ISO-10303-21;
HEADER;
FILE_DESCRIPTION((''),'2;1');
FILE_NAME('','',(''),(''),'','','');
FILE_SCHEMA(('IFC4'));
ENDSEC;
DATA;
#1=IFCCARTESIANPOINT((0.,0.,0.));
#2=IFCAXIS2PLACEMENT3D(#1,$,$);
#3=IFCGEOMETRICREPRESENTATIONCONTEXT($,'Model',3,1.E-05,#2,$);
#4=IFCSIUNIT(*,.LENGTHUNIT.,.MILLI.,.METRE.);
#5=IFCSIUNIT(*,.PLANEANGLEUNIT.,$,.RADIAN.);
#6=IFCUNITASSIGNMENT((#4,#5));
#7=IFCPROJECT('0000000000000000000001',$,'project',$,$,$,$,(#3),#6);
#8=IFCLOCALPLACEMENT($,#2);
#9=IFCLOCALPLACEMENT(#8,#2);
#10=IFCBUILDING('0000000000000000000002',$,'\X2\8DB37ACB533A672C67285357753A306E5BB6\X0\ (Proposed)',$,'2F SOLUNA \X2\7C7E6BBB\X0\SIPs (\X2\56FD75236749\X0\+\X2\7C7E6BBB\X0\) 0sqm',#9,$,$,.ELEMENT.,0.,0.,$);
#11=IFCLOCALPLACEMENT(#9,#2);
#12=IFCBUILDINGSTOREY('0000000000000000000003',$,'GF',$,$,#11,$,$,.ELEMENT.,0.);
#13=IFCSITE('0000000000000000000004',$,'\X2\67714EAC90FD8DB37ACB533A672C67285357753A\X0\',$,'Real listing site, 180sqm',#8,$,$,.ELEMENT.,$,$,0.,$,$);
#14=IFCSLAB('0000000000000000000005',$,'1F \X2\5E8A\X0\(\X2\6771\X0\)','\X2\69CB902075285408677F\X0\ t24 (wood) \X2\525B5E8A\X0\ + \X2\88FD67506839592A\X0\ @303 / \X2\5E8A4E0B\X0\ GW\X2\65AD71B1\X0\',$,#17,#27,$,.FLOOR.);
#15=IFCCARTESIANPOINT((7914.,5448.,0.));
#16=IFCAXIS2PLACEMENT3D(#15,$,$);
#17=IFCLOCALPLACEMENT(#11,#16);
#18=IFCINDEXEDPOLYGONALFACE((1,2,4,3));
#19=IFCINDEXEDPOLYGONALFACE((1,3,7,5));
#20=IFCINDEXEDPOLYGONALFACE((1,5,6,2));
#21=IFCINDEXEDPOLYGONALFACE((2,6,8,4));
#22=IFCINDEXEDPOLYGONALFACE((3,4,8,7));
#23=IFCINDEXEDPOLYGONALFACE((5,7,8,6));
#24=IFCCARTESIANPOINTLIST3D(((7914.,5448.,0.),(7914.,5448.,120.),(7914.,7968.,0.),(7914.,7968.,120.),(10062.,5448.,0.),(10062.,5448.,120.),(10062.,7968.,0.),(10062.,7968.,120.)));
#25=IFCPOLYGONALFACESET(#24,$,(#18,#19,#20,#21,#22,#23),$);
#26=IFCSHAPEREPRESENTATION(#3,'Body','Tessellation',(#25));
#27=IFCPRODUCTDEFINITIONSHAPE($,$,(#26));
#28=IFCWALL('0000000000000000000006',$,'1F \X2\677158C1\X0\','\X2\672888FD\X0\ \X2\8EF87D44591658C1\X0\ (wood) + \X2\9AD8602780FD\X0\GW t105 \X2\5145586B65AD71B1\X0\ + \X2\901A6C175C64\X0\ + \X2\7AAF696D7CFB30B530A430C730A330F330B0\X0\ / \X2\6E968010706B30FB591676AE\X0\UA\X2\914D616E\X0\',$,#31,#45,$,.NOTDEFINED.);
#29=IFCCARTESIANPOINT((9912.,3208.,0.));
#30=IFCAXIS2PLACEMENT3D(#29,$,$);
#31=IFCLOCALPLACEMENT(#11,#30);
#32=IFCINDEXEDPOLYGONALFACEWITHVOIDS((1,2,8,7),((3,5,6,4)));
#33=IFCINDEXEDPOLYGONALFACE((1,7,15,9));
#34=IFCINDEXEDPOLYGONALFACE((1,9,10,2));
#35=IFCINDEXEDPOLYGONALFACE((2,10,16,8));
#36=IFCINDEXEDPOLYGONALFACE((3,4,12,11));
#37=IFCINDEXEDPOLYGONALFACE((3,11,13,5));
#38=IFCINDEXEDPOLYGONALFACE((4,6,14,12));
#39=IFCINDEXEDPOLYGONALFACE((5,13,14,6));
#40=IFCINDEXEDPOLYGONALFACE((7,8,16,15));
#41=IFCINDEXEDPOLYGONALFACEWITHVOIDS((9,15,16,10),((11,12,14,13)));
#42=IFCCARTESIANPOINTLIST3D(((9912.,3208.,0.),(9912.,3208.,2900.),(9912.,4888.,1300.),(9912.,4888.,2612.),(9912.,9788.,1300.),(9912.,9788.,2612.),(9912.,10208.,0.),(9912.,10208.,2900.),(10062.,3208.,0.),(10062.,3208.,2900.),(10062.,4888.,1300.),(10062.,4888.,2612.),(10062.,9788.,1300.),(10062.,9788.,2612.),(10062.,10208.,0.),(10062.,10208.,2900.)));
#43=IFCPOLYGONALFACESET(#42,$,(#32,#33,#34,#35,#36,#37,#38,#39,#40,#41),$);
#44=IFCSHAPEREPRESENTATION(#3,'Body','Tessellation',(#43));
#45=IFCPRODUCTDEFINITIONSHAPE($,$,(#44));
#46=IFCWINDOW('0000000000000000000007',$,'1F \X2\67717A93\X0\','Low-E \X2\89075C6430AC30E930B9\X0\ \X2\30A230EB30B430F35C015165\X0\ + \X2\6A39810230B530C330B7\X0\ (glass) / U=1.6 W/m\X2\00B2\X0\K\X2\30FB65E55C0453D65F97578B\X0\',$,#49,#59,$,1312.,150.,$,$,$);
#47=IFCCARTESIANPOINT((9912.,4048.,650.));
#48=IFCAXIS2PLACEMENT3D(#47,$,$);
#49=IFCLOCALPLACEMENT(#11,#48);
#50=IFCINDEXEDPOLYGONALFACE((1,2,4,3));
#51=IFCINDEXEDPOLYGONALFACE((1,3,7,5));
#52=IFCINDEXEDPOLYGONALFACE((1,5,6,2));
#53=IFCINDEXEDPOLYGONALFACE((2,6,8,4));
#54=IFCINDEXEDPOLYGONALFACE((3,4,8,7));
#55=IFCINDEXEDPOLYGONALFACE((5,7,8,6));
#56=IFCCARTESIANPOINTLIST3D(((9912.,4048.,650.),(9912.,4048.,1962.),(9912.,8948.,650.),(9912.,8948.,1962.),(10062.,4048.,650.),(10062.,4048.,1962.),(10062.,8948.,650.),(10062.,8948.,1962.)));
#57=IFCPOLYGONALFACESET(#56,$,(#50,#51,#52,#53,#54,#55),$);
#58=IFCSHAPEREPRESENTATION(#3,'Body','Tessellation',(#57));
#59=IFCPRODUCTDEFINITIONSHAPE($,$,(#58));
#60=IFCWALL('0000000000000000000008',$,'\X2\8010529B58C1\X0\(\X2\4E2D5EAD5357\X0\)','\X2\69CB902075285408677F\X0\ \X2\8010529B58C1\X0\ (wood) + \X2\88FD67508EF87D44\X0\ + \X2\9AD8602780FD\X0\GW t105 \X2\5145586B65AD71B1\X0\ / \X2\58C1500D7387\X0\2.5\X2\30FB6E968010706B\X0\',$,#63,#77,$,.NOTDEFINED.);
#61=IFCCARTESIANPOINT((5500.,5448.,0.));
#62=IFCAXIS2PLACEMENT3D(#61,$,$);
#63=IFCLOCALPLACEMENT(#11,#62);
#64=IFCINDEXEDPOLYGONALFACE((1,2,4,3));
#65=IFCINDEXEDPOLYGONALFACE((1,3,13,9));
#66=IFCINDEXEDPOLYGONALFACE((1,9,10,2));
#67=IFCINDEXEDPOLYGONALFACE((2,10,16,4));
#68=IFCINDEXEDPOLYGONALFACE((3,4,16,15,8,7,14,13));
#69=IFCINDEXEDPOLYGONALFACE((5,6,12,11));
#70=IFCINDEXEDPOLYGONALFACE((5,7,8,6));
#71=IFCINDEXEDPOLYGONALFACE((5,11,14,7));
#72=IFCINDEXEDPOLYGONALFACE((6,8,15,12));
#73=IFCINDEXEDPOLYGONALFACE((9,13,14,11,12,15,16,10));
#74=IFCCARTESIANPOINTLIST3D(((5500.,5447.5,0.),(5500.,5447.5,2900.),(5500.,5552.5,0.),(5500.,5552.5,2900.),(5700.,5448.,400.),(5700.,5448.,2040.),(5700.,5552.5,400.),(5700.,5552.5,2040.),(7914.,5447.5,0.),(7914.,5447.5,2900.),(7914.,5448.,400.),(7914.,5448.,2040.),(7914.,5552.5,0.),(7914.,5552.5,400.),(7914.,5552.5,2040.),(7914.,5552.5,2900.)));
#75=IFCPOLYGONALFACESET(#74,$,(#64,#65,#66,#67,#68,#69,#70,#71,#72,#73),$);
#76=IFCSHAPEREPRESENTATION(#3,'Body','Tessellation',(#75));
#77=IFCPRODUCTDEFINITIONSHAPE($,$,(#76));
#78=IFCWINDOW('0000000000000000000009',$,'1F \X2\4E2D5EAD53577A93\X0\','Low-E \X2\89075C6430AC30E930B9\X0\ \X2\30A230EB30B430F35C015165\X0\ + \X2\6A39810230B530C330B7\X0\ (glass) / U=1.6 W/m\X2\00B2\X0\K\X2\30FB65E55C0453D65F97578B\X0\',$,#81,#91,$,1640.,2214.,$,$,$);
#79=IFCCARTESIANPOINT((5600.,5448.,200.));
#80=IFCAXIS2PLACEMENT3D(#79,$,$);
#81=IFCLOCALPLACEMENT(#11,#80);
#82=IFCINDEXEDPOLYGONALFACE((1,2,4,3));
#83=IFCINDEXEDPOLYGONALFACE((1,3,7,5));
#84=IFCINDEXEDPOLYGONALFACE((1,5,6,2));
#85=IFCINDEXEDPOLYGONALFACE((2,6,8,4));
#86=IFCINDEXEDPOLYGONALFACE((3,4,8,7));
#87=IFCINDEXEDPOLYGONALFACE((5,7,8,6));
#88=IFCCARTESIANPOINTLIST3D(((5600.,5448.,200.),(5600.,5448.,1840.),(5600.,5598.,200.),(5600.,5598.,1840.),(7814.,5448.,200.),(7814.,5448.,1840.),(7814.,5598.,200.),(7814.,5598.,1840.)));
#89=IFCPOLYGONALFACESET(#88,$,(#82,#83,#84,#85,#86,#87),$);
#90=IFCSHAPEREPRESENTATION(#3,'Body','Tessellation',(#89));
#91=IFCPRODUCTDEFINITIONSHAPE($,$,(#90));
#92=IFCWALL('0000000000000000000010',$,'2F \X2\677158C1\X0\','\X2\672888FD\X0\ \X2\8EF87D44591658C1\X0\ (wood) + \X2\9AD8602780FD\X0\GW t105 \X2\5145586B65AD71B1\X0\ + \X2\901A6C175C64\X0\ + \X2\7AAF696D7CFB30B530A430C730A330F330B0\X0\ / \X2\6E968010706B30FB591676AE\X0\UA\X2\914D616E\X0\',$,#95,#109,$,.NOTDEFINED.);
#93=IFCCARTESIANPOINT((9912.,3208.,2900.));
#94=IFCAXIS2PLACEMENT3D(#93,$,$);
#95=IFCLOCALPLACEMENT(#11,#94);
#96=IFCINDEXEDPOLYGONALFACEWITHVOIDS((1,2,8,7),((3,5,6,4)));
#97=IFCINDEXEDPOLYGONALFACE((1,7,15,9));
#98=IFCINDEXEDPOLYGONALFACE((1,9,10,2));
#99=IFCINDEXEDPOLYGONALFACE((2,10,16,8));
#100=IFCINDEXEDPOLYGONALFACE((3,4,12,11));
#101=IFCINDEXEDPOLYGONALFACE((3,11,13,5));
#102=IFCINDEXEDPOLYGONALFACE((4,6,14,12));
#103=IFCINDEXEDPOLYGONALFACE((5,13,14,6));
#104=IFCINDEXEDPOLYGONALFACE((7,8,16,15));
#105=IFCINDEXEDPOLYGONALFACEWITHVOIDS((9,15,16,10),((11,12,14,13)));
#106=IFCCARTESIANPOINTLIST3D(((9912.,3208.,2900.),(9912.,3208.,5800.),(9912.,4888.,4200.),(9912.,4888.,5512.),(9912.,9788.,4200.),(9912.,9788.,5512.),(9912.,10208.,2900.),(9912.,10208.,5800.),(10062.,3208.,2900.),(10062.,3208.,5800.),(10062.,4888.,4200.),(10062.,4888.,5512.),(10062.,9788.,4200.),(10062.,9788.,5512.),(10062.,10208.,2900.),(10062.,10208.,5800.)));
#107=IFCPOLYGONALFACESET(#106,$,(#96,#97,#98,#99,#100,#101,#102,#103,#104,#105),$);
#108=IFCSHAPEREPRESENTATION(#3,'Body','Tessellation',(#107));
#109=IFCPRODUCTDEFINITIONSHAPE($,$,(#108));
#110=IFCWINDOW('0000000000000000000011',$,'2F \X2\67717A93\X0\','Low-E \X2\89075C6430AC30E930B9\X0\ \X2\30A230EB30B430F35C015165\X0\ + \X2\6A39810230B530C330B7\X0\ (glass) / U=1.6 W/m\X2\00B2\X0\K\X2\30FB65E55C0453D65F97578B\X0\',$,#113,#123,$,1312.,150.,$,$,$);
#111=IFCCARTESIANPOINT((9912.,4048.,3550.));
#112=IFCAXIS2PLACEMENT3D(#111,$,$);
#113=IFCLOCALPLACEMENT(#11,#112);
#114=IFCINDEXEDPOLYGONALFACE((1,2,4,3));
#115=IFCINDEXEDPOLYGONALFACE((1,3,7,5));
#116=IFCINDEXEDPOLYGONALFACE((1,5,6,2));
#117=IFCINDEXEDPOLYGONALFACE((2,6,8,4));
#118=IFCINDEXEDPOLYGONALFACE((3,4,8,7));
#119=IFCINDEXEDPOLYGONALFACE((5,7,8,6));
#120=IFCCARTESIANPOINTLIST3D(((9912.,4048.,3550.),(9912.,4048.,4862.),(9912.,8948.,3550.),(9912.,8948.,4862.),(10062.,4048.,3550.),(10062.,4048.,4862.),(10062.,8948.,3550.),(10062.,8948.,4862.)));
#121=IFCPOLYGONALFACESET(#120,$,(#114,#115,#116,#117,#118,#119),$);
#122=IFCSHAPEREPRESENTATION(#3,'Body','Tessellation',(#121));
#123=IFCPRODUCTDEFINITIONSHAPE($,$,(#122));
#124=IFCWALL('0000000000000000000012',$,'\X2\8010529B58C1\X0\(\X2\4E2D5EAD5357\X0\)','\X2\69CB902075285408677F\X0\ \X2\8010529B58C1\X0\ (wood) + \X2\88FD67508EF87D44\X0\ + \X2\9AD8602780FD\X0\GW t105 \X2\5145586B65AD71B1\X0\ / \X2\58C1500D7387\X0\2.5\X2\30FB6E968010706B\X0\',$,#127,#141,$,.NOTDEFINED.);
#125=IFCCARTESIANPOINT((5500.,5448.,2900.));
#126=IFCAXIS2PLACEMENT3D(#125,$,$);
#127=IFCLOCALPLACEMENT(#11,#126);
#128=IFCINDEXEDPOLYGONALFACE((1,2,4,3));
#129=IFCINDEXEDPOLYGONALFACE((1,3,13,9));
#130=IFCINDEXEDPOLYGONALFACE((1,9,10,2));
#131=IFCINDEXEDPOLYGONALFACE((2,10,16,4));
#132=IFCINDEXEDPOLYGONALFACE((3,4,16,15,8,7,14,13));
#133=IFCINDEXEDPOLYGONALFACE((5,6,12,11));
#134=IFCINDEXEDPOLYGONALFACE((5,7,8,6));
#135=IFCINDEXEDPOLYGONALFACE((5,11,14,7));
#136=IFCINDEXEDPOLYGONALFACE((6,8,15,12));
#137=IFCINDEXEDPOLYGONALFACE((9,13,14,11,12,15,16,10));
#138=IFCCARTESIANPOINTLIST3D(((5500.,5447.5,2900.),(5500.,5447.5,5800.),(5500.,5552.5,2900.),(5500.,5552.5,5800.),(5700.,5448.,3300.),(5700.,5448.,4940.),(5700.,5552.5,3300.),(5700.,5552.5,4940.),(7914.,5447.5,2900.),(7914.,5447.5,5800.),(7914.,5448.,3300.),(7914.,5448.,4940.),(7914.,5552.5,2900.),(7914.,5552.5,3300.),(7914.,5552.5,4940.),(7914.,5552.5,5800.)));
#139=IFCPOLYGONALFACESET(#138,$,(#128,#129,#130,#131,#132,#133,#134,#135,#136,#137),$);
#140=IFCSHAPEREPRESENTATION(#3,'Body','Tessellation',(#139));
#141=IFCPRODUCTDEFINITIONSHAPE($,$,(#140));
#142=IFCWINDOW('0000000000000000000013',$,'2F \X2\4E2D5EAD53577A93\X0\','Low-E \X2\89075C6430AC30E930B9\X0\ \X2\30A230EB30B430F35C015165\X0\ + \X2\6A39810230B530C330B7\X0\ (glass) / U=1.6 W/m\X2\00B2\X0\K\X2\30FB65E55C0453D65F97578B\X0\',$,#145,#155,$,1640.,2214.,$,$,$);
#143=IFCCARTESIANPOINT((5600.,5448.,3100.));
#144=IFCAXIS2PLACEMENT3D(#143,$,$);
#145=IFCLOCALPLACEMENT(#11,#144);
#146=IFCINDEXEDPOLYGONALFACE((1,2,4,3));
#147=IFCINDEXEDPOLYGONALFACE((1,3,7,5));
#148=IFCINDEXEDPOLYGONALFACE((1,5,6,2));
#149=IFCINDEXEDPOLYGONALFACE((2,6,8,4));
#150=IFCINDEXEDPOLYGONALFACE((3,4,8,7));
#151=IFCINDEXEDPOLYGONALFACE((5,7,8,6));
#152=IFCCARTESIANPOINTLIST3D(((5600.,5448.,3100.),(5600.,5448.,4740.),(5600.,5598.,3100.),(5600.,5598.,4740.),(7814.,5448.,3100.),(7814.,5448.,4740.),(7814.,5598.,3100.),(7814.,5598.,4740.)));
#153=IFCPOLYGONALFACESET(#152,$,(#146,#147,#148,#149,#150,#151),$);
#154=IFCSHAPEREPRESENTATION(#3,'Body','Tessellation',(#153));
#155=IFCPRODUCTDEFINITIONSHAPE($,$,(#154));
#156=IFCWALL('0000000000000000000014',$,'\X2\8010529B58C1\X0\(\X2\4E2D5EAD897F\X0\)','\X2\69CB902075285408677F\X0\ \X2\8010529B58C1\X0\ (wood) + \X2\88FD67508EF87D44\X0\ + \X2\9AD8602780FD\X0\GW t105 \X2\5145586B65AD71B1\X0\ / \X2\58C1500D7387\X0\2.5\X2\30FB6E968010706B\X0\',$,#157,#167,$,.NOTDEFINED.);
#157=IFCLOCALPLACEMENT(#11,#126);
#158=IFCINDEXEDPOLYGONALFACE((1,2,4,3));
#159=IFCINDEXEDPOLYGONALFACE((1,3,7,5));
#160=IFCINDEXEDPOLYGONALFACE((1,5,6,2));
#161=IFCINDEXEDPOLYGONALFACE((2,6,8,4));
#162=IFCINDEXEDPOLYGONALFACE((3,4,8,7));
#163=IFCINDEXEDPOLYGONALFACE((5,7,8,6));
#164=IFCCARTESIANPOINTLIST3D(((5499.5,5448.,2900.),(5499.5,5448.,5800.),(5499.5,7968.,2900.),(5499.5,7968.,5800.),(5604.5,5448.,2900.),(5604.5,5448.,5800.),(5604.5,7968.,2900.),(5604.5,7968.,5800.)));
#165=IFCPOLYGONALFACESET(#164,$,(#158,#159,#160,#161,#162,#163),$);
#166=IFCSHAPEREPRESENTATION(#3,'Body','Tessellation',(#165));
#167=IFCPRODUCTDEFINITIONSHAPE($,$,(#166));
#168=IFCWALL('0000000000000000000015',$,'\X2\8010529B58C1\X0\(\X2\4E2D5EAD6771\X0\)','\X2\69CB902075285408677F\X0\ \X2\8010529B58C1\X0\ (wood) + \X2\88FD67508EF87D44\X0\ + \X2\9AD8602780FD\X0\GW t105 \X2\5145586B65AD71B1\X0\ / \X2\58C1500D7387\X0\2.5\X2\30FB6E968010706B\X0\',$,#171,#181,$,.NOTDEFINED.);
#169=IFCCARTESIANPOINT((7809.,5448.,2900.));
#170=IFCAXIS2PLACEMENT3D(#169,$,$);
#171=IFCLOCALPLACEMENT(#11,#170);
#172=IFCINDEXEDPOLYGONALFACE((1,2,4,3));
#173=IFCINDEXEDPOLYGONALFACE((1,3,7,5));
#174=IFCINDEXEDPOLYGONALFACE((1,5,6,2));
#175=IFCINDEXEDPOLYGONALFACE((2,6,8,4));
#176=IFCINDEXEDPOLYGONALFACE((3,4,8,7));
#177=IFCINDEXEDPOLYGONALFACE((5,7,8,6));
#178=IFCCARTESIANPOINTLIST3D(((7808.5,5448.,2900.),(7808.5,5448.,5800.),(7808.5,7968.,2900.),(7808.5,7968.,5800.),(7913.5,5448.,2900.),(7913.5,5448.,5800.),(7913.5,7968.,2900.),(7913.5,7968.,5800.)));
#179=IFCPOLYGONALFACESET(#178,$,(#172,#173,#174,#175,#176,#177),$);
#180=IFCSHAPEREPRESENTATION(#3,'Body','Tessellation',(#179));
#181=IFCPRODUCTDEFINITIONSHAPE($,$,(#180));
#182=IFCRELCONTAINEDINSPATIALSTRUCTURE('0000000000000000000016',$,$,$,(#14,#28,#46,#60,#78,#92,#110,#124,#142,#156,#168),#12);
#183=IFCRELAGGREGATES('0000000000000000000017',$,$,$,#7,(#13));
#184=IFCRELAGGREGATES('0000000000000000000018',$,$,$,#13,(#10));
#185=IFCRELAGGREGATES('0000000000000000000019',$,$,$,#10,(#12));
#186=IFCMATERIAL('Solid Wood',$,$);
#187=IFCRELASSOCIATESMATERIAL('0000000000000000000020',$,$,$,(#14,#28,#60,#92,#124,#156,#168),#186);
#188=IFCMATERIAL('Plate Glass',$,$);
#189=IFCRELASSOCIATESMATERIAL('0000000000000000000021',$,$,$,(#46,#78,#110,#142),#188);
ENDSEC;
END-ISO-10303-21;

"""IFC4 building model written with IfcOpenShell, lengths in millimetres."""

from ifc_helpers import new_model, si_unit, frame, frame_2d, origin, place, context, project, spatial, rectangle, extrude, material, element, fill, save


model = new_model("IFC4")

# Units and contexts
model_context = context("Model", 3, precision=1e-05, world=origin())
ifc_project = project(units=[si_unit("LENGTHUNIT", "METRE", prefix="MILLI"), si_unit("PLANEANGLEUNIT", "RADIAN")], contexts=[model_context])

# Site, building, storey
site_placement = place(None, origin())
site = spatial("IfcSite", under=ifc_project, at=site_placement, Name="東京都足立区本木南町", ObjectType="Real listing site, 180sqm", CompositionType="ELEMENT", RefElevation=0.0)
building_placement = place(site_placement, origin())
building = spatial("IfcBuilding", under=site, at=building_placement, Name="足立区本木南町の家 (Proposed)", ObjectType="2F SOLUNA 籾殻SIPs (国産杉+籾殻) 0sqm", CompositionType="ELEMENT", ElevationOfRefHeight=0.0, ElevationOfTerrain=0.0)
storey_placement = place(building_placement, origin())
storey = spatial("IfcBuildingStorey", under=building, at=storey_placement, Name="GF", CompositionType="ELEMENT", Elevation=0.0)

# Slab
ifc_material_1 = material(Name="Solid Wood")
slab_placement = place(storey_placement, frame((7914.0, 5448.0, 0.0)))
element("IfcSlab", 1, at=slab_placement, inside=storey, material=ifc_material_1, Name="1F 床(東)", Description="構造用合板 t24 (wood) 剛床 + 製材根太 @303 / 床下 GW断熱", PredefinedType="FLOOR", context=model_context, shape_type="SweptSolid", body=[
    extrude(rectangle(XDim=2148.0, YDim=2520.0, at=frame_2d((1074.0, 1260.0))), frame((7914.0, 5448.0, 0.0)), (0.0, 0.0, 1.0), 120.0),
])

# Walls, openings, windows
wall_1_placement = place(storey_placement, frame((9912.0, 3208.0, 0.0)))
wall_1 = element("IfcWall", 2, at=wall_1_placement, inside=storey, material=ifc_material_1, Name="1F 東壁", Description="木製 軸組外壁 (wood) + 高性能GW t105 充填断熱 + 通気層 + 窯業系サイディング / 準耐火・外皮UA配慮", PredefinedType="NOTDEFINED", context=model_context, shape_type="SweptSolid", body=[
    extrude(rectangle(XDim=150.0, YDim=7000.0, at=frame_2d((75.0, 3500.0))), frame((9912.0, 3208.0, 0.0)), (0.0, 0.0, 1.0), 2900.0),
])
opening_1_placement = place(storey_placement, frame((9912.0, 4048.0, 650.0)))
opening_1 = element("IfcOpeningElement", 3, at=opening_1_placement, cuts=wall_1, PredefinedType="NOTDEFINED", context=model_context, shape_type="SweptSolid", body=[
    extrude(rectangle(XDim=150.0, YDim=4900.0, at=frame_2d((75.0, 2450.0))), frame((9912.0, 4048.0, 650.0)), (0.0, 0.0, 1.0), 1312.0),
])
ifc_material_2 = material(Name="Plate Glass")
window_1_placement = place(storey_placement, frame((9912.0, 4048.0, 650.0)))
window_1 = element("IfcWindow", 4, at=window_1_placement, inside=storey, material=ifc_material_2, Name="1F 東窓", Description="Low-E 複層ガラス アルゴン封入 + 樹脂サッシ (glass) / U=1.6 W/m²K・日射取得型", OverallHeight=1312.0, OverallWidth=150.0, context=model_context, shape_type="SweptSolid", body=[
    extrude(rectangle(XDim=150.0, YDim=4900.0, at=frame_2d((75.0, 2450.0))), frame((9912.0, 4048.0, 650.0)), (0.0, 0.0, 1.0), 1312.0),
])
fill(opening_1, window_1)
wall_2_placement = place(storey_placement, frame((5500.0, 5448.0, 0.0)))
wall_2 = element("IfcWall", 5, at=wall_2_placement, inside=storey, material=ifc_material_1, Name="耐力壁(中庭南)", Description="構造用合板 耐力壁 (wood) + 製材軸組 + 高性能GW t105 充填断熱 / 壁倍率2.5・準耐火", PredefinedType="NOTDEFINED", context=model_context, shape_type="SweptSolid", body=[
    extrude(rectangle(XDim=2414.0, YDim=105.0, at=frame_2d((1207.0, 52.0))), frame((5500.0, 5448.0, 0.0)), (0.0, 0.0, 1.0), 2900.0),
])
opening_2_placement = place(storey_placement, frame((5600.0, 5448.0, 200.0)))
opening_2 = element("IfcOpeningElement", 6, at=opening_2_placement, cuts=wall_2, PredefinedType="NOTDEFINED", context=model_context, shape_type="SweptSolid", body=[
    extrude(rectangle(XDim=2214.0, YDim=150.0, at=frame_2d((1107.0, 75.0))), frame((5600.0, 5448.0, 200.0)), (0.0, 0.0, 1.0), 1640.0),
])
window_2_placement = place(storey_placement, frame((5600.0, 5448.0, 200.0)))
window_2 = element("IfcWindow", 7, at=window_2_placement, inside=storey, material=ifc_material_2, Name="1F 中庭南窓", Description="Low-E 複層ガラス アルゴン封入 + 樹脂サッシ (glass) / U=1.6 W/m²K・日射取得型", OverallHeight=1640.0, OverallWidth=2214.0, context=model_context, shape_type="SweptSolid", body=[
    extrude(rectangle(XDim=2214.0, YDim=150.0, at=frame_2d((1107.0, 75.0))), frame((5600.0, 5448.0, 200.0)), (0.0, 0.0, 1.0), 1640.0),
])
fill(opening_2, window_2)

# Walls, openings, windows
wall_3_placement = place(storey_placement, frame((9912.0, 3208.0, 2900.0)))
wall_3 = element("IfcWall", 8, at=wall_3_placement, inside=storey, material=ifc_material_1, Name="2F 東壁", Description="木製 軸組外壁 (wood) + 高性能GW t105 充填断熱 + 通気層 + 窯業系サイディング / 準耐火・外皮UA配慮", PredefinedType="NOTDEFINED", context=model_context, shape_type="SweptSolid", body=[
    extrude(rectangle(XDim=150.0, YDim=7000.0, at=frame_2d((75.0, 3500.0))), frame((9912.0, 3208.0, 2900.0)), (0.0, 0.0, 1.0), 2900.0),
])
opening_3_placement = place(storey_placement, frame((9912.0, 4048.0, 3550.0)))
opening_3 = element("IfcOpeningElement", 9, at=opening_3_placement, cuts=wall_3, PredefinedType="NOTDEFINED", context=model_context, shape_type="SweptSolid", body=[
    extrude(rectangle(XDim=150.0, YDim=4900.0, at=frame_2d((75.0, 2450.0))), frame((9912.0, 4048.0, 3550.0)), (0.0, 0.0, 1.0), 1312.0),
])
window_3_placement = place(storey_placement, frame((9912.0, 4048.0, 3550.0)))
window_3 = element("IfcWindow", 10, at=window_3_placement, inside=storey, material=ifc_material_2, Name="2F 東窓", Description="Low-E 複層ガラス アルゴン封入 + 樹脂サッシ (glass) / U=1.6 W/m²K・日射取得型", OverallHeight=1312.0, OverallWidth=150.0, context=model_context, shape_type="SweptSolid", body=[
    extrude(rectangle(XDim=150.0, YDim=4900.0, at=frame_2d((75.0, 2450.0))), frame((9912.0, 4048.0, 3550.0)), (0.0, 0.0, 1.0), 1312.0),
])
fill(opening_3, window_3)
wall_4_placement = place(storey_placement, frame((5500.0, 5448.0, 2900.0)))
wall_4 = element("IfcWall", 11, at=wall_4_placement, inside=storey, material=ifc_material_1, Name="耐力壁(中庭南)", Description="構造用合板 耐力壁 (wood) + 製材軸組 + 高性能GW t105 充填断熱 / 壁倍率2.5・準耐火", PredefinedType="NOTDEFINED", context=model_context, shape_type="SweptSolid", body=[
    extrude(rectangle(XDim=2414.0, YDim=105.0, at=frame_2d((1207.0, 52.0))), frame((5500.0, 5448.0, 2900.0)), (0.0, 0.0, 1.0), 2900.0),
])
opening_4_placement = place(storey_placement, frame((5600.0, 5448.0, 3100.0)))
opening_4 = element("IfcOpeningElement", 12, at=opening_4_placement, cuts=wall_4, PredefinedType="NOTDEFINED", context=model_context, shape_type="SweptSolid", body=[
    extrude(rectangle(XDim=2214.0, YDim=150.0, at=frame_2d((1107.0, 75.0))), frame((5600.0, 5448.0, 3100.0)), (0.0, 0.0, 1.0), 1640.0),
])
window_4_placement = place(storey_placement, frame((5600.0, 5448.0, 3100.0)))
window_4 = element("IfcWindow", 13, at=window_4_placement, inside=storey, material=ifc_material_2, Name="2F 中庭南窓", Description="Low-E 複層ガラス アルゴン封入 + 樹脂サッシ (glass) / U=1.6 W/m²K・日射取得型", OverallHeight=1640.0, OverallWidth=2214.0, context=model_context, shape_type="SweptSolid", body=[
    extrude(rectangle(XDim=2214.0, YDim=150.0, at=frame_2d((1107.0, 75.0))), frame((5600.0, 5448.0, 3100.0)), (0.0, 0.0, 1.0), 1640.0),
])
fill(opening_4, window_4)

# Walls
wall_5_placement = place(storey_placement, frame((5500.0, 5448.0, 2900.0)))
element("IfcWall", 14, at=wall_5_placement, inside=storey, material=ifc_material_1, Name="耐力壁(中庭西)", Description="構造用合板 耐力壁 (wood) + 製材軸組 + 高性能GW t105 充填断熱 / 壁倍率2.5・準耐火", PredefinedType="NOTDEFINED", context=model_context, shape_type="SweptSolid", body=[
    extrude(rectangle(XDim=105.0, YDim=2520.0, at=frame_2d((52.0, 1260.0))), frame((5500.0, 5448.0, 2900.0)), (0.0, 0.0, 1.0), 2900.0),
])
wall_6_placement = place(storey_placement, frame((7809.0, 5448.0, 2900.0)))
element("IfcWall", 15, at=wall_6_placement, inside=storey, material=ifc_material_1, Name="耐力壁(中庭東)", Description="構造用合板 耐力壁 (wood) + 製材軸組 + 高性能GW t105 充填断熱 / 壁倍率2.5・準耐火", PredefinedType="NOTDEFINED", context=model_context, shape_type="SweptSolid", body=[
    extrude(rectangle(XDim=105.0, YDim=2520.0, at=frame_2d((52.0, 1260.0))), frame((7809.0, 5448.0, 2900.0)), (0.0, 0.0, 1.0), 2900.0),
])

save(model, "model.ifc")
